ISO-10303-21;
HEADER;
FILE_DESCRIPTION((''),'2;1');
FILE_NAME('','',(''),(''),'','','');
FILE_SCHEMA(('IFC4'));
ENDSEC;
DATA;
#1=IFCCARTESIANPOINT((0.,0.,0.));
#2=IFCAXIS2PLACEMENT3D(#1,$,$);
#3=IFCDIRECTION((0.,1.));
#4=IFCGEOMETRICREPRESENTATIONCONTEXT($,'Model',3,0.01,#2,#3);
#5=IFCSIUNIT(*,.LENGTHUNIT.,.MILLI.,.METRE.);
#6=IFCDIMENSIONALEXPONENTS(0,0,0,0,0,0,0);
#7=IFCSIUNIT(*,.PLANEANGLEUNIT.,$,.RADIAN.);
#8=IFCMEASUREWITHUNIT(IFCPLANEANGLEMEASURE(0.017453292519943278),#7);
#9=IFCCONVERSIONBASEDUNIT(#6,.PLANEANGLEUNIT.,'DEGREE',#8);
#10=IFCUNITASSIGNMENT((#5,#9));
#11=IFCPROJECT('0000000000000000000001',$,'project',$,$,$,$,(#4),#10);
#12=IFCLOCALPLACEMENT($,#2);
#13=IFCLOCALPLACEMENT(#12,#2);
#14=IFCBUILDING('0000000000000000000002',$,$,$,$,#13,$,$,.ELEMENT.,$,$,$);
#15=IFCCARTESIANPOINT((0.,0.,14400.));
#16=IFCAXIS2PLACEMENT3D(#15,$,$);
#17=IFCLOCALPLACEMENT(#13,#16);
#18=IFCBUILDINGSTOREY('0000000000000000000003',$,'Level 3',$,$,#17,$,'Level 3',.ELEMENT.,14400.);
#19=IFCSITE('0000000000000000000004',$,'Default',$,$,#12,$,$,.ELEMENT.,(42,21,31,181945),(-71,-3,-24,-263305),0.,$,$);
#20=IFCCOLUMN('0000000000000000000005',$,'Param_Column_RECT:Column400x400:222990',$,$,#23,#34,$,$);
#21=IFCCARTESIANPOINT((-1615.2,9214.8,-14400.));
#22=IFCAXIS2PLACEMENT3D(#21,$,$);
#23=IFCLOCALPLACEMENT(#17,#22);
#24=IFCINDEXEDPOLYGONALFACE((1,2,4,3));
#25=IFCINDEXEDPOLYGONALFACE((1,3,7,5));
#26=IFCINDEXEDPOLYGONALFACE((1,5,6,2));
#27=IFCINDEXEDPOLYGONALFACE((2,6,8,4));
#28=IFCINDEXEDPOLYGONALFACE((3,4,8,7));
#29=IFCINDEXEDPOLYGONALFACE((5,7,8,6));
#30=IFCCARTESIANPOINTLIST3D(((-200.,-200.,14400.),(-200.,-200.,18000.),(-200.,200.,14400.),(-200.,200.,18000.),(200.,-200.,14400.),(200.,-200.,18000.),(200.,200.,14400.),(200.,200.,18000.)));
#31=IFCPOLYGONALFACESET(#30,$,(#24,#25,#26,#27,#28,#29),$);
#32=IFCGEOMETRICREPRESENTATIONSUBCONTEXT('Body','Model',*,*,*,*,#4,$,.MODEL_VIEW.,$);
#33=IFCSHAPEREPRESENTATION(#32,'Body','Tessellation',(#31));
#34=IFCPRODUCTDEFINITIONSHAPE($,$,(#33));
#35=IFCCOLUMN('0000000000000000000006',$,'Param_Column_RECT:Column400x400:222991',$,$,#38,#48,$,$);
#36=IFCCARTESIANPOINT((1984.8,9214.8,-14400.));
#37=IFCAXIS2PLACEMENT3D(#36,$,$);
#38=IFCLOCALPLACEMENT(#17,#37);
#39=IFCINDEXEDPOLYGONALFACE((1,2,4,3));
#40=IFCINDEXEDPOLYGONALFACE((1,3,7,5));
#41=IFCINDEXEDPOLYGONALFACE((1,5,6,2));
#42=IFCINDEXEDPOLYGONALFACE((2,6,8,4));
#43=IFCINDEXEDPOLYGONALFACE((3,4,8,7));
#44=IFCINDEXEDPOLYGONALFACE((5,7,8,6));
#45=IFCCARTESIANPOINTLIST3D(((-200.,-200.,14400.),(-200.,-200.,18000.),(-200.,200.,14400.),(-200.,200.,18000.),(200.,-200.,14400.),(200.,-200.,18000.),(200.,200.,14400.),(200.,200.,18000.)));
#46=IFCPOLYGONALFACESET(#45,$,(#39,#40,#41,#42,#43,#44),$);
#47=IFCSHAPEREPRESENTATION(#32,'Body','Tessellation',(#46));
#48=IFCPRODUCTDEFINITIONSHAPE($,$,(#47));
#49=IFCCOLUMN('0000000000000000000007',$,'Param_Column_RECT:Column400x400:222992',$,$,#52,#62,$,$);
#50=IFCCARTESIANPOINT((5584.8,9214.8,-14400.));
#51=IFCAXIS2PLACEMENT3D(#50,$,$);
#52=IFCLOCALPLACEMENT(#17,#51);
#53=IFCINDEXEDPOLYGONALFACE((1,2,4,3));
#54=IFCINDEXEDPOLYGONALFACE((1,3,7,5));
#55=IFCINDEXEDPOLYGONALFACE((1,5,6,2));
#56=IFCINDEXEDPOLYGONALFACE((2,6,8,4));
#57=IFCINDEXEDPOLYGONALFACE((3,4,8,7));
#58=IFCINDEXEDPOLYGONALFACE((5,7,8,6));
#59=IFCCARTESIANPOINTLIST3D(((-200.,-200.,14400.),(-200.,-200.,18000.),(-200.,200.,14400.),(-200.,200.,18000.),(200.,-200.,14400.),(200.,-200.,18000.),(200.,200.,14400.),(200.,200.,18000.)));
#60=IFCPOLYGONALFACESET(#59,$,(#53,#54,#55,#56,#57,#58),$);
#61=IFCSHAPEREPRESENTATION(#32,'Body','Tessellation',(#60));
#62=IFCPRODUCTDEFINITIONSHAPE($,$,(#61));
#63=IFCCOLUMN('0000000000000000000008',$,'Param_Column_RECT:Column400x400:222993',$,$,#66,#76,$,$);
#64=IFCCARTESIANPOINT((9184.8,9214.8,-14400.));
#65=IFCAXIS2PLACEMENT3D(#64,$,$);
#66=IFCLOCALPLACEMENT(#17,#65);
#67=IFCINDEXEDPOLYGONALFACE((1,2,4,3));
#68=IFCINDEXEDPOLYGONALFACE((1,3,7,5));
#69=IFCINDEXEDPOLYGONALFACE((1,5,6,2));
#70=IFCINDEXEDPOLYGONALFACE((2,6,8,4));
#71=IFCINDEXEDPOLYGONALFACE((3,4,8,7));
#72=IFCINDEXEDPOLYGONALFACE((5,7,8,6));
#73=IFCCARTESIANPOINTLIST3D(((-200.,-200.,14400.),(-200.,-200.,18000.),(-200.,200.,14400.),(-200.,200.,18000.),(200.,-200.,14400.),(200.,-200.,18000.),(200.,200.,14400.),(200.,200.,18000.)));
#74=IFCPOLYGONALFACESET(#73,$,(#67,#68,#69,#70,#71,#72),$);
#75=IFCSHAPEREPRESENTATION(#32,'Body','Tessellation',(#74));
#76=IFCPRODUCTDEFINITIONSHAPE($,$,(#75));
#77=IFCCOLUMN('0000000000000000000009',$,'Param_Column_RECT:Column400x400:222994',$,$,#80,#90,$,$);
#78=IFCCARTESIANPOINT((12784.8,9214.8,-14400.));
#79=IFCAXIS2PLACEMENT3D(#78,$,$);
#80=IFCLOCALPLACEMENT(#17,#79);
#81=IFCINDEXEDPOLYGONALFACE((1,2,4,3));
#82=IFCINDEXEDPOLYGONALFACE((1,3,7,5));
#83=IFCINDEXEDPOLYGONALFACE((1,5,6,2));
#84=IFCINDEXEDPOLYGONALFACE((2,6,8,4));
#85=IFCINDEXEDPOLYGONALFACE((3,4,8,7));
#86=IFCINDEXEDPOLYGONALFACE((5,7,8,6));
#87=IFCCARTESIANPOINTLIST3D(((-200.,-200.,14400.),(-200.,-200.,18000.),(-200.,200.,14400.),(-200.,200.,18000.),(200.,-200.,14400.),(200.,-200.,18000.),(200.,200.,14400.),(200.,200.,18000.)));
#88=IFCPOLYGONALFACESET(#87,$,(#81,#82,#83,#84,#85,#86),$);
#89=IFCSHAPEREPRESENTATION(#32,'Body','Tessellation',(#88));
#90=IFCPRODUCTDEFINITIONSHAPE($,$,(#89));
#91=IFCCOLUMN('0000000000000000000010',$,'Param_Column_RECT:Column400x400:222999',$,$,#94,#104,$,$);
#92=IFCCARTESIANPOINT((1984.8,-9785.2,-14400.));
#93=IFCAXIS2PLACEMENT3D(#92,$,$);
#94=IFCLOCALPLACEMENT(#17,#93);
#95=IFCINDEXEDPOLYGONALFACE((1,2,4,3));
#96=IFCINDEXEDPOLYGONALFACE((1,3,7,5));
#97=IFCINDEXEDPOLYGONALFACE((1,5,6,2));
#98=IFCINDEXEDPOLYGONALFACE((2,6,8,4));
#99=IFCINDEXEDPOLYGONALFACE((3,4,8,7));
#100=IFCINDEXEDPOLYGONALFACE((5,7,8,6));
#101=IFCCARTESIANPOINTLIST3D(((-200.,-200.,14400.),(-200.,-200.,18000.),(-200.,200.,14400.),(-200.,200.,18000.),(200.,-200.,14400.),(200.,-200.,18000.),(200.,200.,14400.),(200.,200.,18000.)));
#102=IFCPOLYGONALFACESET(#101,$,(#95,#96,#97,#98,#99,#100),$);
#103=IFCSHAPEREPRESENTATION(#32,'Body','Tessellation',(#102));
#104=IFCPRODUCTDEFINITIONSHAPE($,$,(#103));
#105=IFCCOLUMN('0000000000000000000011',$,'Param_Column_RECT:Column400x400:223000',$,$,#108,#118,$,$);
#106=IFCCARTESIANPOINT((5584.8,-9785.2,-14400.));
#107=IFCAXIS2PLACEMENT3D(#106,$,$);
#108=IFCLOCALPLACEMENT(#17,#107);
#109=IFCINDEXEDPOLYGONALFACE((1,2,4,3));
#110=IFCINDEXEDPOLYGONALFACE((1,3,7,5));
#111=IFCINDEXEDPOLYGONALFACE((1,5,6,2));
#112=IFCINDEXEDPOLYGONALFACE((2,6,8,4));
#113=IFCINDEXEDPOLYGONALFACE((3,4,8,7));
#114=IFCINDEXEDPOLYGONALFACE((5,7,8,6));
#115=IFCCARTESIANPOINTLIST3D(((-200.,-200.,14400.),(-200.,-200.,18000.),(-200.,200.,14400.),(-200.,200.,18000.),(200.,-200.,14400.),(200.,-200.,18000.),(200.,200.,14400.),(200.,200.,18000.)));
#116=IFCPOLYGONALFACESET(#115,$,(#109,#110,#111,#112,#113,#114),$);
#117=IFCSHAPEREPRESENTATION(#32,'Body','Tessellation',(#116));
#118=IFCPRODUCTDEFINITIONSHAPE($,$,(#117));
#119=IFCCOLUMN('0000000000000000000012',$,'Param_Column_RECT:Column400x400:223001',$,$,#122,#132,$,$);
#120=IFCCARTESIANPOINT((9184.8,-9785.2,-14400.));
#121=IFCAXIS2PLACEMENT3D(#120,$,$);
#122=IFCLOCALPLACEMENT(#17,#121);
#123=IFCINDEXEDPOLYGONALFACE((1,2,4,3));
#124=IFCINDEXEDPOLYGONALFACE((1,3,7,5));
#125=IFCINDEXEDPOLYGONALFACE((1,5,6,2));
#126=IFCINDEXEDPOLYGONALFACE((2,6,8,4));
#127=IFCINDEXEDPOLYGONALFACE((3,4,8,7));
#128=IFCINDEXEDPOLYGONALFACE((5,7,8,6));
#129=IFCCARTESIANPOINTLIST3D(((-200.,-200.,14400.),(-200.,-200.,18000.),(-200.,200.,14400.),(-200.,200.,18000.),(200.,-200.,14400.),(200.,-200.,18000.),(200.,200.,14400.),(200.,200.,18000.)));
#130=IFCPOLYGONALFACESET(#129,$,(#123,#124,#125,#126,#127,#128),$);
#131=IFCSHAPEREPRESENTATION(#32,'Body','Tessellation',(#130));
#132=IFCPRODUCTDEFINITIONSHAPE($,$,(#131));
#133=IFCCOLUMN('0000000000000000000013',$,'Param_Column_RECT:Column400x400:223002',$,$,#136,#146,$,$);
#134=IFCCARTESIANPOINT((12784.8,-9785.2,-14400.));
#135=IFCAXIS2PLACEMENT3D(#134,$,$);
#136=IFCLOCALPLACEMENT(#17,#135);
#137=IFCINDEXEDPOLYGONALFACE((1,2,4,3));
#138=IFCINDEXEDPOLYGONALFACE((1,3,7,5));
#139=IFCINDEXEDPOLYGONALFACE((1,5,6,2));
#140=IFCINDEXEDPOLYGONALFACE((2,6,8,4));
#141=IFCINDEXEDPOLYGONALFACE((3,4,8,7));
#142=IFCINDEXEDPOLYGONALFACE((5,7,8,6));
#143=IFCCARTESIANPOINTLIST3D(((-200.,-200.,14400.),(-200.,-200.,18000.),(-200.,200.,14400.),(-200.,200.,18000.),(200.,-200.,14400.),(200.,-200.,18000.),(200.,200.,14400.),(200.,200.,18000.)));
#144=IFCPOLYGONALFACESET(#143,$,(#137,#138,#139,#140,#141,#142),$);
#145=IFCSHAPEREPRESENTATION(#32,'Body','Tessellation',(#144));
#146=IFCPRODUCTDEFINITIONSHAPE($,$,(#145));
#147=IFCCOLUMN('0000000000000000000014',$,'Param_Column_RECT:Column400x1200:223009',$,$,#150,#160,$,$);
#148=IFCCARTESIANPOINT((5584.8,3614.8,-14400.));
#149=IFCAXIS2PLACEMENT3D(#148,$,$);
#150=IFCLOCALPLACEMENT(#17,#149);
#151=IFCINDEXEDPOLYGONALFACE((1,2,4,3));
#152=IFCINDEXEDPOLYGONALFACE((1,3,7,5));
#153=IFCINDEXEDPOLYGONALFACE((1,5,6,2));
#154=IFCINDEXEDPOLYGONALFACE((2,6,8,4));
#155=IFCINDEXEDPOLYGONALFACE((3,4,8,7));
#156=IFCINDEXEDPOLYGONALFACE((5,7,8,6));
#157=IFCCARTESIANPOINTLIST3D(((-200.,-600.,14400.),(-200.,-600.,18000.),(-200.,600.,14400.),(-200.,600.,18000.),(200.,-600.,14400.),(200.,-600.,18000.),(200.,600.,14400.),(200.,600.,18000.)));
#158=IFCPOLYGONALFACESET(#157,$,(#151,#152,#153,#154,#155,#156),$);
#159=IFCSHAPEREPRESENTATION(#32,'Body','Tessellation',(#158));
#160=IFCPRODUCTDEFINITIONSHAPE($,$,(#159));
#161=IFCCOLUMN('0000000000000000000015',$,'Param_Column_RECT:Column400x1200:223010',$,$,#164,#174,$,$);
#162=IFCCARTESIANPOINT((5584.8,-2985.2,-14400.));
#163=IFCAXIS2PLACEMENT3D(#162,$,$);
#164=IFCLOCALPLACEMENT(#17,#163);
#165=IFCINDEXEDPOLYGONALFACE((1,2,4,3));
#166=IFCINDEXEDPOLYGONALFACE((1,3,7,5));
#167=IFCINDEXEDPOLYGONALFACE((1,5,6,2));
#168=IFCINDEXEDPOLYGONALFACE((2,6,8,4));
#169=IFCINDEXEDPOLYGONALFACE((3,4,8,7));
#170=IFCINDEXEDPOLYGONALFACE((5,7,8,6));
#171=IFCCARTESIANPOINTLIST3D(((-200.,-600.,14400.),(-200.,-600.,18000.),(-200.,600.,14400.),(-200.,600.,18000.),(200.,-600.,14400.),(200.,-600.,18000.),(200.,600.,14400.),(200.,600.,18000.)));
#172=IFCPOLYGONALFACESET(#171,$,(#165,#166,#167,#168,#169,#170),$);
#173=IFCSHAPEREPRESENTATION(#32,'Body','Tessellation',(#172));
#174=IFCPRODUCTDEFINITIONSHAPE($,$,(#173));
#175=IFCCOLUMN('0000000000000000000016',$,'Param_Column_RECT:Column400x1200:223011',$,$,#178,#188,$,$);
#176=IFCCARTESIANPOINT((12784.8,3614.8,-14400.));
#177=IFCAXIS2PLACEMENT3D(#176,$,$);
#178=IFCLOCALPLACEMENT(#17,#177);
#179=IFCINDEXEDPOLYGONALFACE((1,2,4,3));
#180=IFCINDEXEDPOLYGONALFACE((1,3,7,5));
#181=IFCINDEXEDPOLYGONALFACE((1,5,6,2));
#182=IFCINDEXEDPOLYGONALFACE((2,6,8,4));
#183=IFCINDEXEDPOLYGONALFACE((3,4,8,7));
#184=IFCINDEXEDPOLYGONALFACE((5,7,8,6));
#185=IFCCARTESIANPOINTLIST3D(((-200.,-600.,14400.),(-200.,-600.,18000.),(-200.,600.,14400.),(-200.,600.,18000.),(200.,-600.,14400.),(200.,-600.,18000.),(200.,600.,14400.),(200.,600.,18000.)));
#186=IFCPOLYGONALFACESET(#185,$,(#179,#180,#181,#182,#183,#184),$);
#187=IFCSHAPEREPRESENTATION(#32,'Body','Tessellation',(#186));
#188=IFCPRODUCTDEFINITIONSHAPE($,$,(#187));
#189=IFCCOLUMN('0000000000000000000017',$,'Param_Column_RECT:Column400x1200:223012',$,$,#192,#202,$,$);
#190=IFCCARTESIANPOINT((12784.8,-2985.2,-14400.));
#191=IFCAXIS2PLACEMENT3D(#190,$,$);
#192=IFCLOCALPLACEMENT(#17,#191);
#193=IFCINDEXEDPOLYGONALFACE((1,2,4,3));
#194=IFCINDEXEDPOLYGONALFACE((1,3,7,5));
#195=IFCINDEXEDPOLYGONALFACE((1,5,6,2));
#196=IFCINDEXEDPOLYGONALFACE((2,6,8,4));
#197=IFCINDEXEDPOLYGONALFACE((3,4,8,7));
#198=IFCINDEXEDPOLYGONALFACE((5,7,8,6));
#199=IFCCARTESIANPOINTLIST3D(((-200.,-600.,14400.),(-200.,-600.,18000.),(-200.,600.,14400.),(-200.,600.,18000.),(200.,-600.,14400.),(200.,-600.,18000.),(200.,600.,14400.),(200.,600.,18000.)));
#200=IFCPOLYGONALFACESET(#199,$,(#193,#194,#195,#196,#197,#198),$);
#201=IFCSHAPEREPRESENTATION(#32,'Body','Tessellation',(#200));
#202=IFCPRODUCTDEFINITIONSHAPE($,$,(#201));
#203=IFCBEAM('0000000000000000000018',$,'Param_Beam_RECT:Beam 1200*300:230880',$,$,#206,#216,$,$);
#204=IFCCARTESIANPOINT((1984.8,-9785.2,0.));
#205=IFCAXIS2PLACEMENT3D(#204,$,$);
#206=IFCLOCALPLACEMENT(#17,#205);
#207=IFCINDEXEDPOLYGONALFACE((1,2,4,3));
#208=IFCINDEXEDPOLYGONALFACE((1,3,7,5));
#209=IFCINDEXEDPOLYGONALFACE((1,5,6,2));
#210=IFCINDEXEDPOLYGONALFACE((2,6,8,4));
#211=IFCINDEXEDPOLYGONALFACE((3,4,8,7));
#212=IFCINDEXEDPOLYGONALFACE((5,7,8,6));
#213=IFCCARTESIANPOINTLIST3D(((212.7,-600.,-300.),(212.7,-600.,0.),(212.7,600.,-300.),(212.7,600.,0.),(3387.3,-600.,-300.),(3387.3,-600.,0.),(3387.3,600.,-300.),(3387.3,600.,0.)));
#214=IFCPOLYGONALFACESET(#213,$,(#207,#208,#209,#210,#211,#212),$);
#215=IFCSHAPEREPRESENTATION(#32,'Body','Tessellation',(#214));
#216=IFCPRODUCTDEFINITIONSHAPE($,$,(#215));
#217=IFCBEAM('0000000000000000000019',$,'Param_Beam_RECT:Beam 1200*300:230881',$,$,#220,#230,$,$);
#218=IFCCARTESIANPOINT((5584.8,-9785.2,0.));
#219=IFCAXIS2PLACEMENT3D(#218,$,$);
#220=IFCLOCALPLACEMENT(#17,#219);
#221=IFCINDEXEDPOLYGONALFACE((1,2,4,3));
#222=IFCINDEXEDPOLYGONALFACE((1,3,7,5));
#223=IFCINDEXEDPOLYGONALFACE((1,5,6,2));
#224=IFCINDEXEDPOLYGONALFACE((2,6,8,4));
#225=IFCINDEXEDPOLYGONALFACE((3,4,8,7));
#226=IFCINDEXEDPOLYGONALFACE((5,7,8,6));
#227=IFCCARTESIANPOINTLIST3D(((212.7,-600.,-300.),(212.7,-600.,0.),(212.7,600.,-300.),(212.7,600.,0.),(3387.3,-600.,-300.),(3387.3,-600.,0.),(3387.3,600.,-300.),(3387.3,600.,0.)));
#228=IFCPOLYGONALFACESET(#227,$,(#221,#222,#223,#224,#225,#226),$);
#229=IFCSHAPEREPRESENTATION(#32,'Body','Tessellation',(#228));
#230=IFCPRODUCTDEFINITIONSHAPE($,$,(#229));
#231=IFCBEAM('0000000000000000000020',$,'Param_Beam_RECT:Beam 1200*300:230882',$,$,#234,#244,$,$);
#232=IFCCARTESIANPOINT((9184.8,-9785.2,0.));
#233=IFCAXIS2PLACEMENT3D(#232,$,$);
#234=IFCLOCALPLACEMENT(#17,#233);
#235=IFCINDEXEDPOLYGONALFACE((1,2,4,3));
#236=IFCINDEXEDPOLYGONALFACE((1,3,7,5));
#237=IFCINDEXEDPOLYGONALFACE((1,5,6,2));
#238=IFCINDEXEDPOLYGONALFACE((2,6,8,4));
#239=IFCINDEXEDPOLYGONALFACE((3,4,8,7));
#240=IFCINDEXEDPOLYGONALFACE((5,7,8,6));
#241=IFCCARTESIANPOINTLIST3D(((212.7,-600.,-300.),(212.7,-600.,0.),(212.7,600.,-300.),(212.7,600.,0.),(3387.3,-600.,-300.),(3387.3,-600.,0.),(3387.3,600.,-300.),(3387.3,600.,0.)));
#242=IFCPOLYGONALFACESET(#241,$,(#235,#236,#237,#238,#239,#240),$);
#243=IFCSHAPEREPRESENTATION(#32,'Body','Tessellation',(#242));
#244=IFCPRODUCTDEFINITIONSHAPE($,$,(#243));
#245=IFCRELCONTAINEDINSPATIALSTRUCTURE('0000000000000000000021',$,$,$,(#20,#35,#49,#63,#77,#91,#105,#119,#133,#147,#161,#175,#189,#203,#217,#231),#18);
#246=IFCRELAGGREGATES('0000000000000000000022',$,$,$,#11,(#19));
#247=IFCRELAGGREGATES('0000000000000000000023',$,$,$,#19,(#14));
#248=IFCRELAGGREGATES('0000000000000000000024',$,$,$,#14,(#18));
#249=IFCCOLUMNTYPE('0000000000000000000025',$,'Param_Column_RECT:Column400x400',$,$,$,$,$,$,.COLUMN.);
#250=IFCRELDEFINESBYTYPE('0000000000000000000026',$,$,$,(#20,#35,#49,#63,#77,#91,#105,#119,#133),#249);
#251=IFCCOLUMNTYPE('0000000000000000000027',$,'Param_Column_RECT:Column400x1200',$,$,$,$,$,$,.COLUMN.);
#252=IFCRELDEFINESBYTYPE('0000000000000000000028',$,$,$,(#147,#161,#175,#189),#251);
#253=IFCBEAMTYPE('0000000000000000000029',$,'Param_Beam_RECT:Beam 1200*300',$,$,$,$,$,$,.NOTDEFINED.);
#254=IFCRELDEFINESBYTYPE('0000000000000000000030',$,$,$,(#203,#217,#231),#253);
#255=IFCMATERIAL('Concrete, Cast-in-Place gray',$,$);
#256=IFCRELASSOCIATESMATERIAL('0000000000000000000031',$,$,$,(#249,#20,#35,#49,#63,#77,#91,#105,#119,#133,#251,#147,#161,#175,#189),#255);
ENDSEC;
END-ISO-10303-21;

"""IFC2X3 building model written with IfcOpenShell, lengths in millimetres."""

from ifc_helpers import new_model, entity, si_unit, converted_unit, direction, frame, frame_2d, origin, origin_2d_with_axis, place, context, subcontext, project, spatial, rectangle, extrude, source, transform, mapped, material, type_object, type_shapes, element, save


model = new_model("IFC2X3")

# Units and contexts
model_context = context("Model", 3, precision=0.01, world=origin(), true_north=direction((0.0, 1.0)))
body_context = subcontext(model_context, "Body", "Model", "MODEL_VIEW")
ifc_project = project(units=[si_unit("LENGTHUNIT", "METRE", prefix="MILLI"), converted_unit("PLANEANGLEUNIT", "DEGREE", entity("IfcPlaneAngleMeasure", 0.017453292519943278), si_unit("PLANEANGLEUNIT", "RADIAN"), dimensions=[0, 0, 0, 0, 0, 0, 0])], contexts=[model_context])

# Site, building, storey
site_placement = place(None, origin())
site = spatial("IfcSite", under=ifc_project, at=site_placement, Name="Default", CompositionType="ELEMENT", RefLatitude=(42, 21, 31, 181945), RefLongitude=(-71, -3, -24, -263305), RefElevation=0.0)
building_placement = place(site_placement, origin())
building = spatial("IfcBuilding", under=site, at=building_placement, CompositionType="ELEMENT")
storey_placement = place(building_placement, frame((0.0, 0.0, 14400.0)))
storey = spatial("IfcBuildingStorey", under=building, at=storey_placement, Name="Level 3", LongName="Level 3", CompositionType="ELEMENT", Elevation=14400.0)

# Columns
ifc_material_1 = material(Name="Concrete, Cast-in-Place gray")
column_type_1 = type_object("IfcColumnType", Name="Param_Column_RECT:Column400x400", PredefinedType="COLUMN", material=ifc_material_1)
shared_shape_1 = source(origin(), body_context, "Body", "SweptSolid", [
    extrude(rectangle(XDim=400.0, YDim=400.0, at=origin_2d_with_axis()), frame((0.0, 0.0, 14400.0), z_axis=(0.0, 0.0, 1.0), x_axis=(-1.0, 0.0, 0.0)), (0.0, 0.0, 1.0), 3600.0),
])
type_shapes(column_type_1, [shared_shape_1])
for number, where, name in (
    (1, (-1615.2, 9214.8, -14400.0), "Param_Column_RECT:Column400x400:222990"),
    (2, (1984.8, 9214.8, -14400.0), "Param_Column_RECT:Column400x400:222991"),
    (3, (5584.8, 9214.8, -14400.0), "Param_Column_RECT:Column400x400:222992"),
    (4, (9184.8, 9214.8, -14400.0), "Param_Column_RECT:Column400x400:222993"),
    (5, (12784.8, 9214.8, -14400.0), "Param_Column_RECT:Column400x400:222994"),
    (6, (1984.8, -9785.2, -14400.0), "Param_Column_RECT:Column400x400:222999"),
    (7, (5584.8, -9785.2, -14400.0), "Param_Column_RECT:Column400x400:223000"),
    (8, (9184.8, -9785.2, -14400.0), "Param_Column_RECT:Column400x400:223001"),
    (9, (12784.8, -9785.2, -14400.0), "Param_Column_RECT:Column400x400:223002"),
):
    element("IfcColumn", number, at=place(storey_placement, frame(where)), inside=storey, type_object=column_type_1, material=ifc_material_1, Name=name, context=body_context, shape_type="MappedRepresentation", body=[
        mapped(shared_shape_1, transform((0.0, 0.0, 0.0), scale=1.0)),
    ])
column_type_2 = type_object("IfcColumnType", Name="Param_Column_RECT:Column400x1200", PredefinedType="COLUMN", material=ifc_material_1)
shared_shape_2 = source(origin(), body_context, "Body", "SweptSolid", [
    extrude(rectangle(XDim=400.0, YDim=1200.0, at=origin_2d_with_axis()), frame((0.0, 0.0, 14400.0), z_axis=(0.0, 0.0, 1.0), x_axis=(-1.0, 0.0, 0.0)), (0.0, 0.0, 1.0), 3600.0),
])
type_shapes(column_type_2, [shared_shape_2])
for number, where, name in (
    (10, (5584.8, 3614.8, -14400.0), "Param_Column_RECT:Column400x1200:223009"),
    (11, (5584.8, -2985.2, -14400.0), "Param_Column_RECT:Column400x1200:223010"),
    (12, (12784.8, 3614.8, -14400.0), "Param_Column_RECT:Column400x1200:223011"),
    (13, (12784.8, -2985.2, -14400.0), "Param_Column_RECT:Column400x1200:223012"),
):
    element("IfcColumn", number, at=place(storey_placement, frame(where)), inside=storey, type_object=column_type_2, material=ifc_material_1, Name=name, context=body_context, shape_type="MappedRepresentation", body=[
        mapped(shared_shape_2, transform((0.0, 0.0, 0.0), scale=1.0)),
    ])

# Beams
beam_type_1 = type_object("IfcBeamType", Name="Param_Beam_RECT:Beam 1200*300", PredefinedType="NOTDEFINED")
beam_1_placement = place(storey_placement, frame((1984.8, -9785.2, 0.0)))
element("IfcBeam", 14, at=beam_1_placement, inside=storey, type_object=beam_type_1, Name="Param_Beam_RECT:Beam 1200*300:230880", context=body_context, shape_type="SweptSolid", body=[
    extrude(rectangle(XDim=300.0, YDim=1200.0, at=origin_2d_with_axis()), frame((212.7, 0.0, -150.0), z_axis=(1.0, 0.0, 0.0), x_axis=(0.0, 0.0, -1.0)), (0.0, 0.0, 1.0), 3174.6),
])
for number, where, name in (
    (15, (5584.8, -9785.2, 0.0), "Param_Beam_RECT:Beam 1200*300:230881"),
    (16, (9184.8, -9785.2, 0.0), "Param_Beam_RECT:Beam 1200*300:230882"),
):
    element("IfcBeam", number, at=place(storey_placement, frame(where)), inside=storey, type_object=beam_type_1, Name=name, context=body_context, shape_type="SweptSolid", body=[
        extrude(rectangle(XDim=300.0, YDim=1200.0, at=frame_2d((0.0, 0.0), x_axis=(1.0, 0.0))), frame((212.7, 0.0, -150.0), z_axis=(1.0, 0.0, 0.0), x_axis=(0.0, 0.0, -1.0)), (0.0, 0.0, 1.0), 3174.6),
    ])

save(model, "model.ifc")
